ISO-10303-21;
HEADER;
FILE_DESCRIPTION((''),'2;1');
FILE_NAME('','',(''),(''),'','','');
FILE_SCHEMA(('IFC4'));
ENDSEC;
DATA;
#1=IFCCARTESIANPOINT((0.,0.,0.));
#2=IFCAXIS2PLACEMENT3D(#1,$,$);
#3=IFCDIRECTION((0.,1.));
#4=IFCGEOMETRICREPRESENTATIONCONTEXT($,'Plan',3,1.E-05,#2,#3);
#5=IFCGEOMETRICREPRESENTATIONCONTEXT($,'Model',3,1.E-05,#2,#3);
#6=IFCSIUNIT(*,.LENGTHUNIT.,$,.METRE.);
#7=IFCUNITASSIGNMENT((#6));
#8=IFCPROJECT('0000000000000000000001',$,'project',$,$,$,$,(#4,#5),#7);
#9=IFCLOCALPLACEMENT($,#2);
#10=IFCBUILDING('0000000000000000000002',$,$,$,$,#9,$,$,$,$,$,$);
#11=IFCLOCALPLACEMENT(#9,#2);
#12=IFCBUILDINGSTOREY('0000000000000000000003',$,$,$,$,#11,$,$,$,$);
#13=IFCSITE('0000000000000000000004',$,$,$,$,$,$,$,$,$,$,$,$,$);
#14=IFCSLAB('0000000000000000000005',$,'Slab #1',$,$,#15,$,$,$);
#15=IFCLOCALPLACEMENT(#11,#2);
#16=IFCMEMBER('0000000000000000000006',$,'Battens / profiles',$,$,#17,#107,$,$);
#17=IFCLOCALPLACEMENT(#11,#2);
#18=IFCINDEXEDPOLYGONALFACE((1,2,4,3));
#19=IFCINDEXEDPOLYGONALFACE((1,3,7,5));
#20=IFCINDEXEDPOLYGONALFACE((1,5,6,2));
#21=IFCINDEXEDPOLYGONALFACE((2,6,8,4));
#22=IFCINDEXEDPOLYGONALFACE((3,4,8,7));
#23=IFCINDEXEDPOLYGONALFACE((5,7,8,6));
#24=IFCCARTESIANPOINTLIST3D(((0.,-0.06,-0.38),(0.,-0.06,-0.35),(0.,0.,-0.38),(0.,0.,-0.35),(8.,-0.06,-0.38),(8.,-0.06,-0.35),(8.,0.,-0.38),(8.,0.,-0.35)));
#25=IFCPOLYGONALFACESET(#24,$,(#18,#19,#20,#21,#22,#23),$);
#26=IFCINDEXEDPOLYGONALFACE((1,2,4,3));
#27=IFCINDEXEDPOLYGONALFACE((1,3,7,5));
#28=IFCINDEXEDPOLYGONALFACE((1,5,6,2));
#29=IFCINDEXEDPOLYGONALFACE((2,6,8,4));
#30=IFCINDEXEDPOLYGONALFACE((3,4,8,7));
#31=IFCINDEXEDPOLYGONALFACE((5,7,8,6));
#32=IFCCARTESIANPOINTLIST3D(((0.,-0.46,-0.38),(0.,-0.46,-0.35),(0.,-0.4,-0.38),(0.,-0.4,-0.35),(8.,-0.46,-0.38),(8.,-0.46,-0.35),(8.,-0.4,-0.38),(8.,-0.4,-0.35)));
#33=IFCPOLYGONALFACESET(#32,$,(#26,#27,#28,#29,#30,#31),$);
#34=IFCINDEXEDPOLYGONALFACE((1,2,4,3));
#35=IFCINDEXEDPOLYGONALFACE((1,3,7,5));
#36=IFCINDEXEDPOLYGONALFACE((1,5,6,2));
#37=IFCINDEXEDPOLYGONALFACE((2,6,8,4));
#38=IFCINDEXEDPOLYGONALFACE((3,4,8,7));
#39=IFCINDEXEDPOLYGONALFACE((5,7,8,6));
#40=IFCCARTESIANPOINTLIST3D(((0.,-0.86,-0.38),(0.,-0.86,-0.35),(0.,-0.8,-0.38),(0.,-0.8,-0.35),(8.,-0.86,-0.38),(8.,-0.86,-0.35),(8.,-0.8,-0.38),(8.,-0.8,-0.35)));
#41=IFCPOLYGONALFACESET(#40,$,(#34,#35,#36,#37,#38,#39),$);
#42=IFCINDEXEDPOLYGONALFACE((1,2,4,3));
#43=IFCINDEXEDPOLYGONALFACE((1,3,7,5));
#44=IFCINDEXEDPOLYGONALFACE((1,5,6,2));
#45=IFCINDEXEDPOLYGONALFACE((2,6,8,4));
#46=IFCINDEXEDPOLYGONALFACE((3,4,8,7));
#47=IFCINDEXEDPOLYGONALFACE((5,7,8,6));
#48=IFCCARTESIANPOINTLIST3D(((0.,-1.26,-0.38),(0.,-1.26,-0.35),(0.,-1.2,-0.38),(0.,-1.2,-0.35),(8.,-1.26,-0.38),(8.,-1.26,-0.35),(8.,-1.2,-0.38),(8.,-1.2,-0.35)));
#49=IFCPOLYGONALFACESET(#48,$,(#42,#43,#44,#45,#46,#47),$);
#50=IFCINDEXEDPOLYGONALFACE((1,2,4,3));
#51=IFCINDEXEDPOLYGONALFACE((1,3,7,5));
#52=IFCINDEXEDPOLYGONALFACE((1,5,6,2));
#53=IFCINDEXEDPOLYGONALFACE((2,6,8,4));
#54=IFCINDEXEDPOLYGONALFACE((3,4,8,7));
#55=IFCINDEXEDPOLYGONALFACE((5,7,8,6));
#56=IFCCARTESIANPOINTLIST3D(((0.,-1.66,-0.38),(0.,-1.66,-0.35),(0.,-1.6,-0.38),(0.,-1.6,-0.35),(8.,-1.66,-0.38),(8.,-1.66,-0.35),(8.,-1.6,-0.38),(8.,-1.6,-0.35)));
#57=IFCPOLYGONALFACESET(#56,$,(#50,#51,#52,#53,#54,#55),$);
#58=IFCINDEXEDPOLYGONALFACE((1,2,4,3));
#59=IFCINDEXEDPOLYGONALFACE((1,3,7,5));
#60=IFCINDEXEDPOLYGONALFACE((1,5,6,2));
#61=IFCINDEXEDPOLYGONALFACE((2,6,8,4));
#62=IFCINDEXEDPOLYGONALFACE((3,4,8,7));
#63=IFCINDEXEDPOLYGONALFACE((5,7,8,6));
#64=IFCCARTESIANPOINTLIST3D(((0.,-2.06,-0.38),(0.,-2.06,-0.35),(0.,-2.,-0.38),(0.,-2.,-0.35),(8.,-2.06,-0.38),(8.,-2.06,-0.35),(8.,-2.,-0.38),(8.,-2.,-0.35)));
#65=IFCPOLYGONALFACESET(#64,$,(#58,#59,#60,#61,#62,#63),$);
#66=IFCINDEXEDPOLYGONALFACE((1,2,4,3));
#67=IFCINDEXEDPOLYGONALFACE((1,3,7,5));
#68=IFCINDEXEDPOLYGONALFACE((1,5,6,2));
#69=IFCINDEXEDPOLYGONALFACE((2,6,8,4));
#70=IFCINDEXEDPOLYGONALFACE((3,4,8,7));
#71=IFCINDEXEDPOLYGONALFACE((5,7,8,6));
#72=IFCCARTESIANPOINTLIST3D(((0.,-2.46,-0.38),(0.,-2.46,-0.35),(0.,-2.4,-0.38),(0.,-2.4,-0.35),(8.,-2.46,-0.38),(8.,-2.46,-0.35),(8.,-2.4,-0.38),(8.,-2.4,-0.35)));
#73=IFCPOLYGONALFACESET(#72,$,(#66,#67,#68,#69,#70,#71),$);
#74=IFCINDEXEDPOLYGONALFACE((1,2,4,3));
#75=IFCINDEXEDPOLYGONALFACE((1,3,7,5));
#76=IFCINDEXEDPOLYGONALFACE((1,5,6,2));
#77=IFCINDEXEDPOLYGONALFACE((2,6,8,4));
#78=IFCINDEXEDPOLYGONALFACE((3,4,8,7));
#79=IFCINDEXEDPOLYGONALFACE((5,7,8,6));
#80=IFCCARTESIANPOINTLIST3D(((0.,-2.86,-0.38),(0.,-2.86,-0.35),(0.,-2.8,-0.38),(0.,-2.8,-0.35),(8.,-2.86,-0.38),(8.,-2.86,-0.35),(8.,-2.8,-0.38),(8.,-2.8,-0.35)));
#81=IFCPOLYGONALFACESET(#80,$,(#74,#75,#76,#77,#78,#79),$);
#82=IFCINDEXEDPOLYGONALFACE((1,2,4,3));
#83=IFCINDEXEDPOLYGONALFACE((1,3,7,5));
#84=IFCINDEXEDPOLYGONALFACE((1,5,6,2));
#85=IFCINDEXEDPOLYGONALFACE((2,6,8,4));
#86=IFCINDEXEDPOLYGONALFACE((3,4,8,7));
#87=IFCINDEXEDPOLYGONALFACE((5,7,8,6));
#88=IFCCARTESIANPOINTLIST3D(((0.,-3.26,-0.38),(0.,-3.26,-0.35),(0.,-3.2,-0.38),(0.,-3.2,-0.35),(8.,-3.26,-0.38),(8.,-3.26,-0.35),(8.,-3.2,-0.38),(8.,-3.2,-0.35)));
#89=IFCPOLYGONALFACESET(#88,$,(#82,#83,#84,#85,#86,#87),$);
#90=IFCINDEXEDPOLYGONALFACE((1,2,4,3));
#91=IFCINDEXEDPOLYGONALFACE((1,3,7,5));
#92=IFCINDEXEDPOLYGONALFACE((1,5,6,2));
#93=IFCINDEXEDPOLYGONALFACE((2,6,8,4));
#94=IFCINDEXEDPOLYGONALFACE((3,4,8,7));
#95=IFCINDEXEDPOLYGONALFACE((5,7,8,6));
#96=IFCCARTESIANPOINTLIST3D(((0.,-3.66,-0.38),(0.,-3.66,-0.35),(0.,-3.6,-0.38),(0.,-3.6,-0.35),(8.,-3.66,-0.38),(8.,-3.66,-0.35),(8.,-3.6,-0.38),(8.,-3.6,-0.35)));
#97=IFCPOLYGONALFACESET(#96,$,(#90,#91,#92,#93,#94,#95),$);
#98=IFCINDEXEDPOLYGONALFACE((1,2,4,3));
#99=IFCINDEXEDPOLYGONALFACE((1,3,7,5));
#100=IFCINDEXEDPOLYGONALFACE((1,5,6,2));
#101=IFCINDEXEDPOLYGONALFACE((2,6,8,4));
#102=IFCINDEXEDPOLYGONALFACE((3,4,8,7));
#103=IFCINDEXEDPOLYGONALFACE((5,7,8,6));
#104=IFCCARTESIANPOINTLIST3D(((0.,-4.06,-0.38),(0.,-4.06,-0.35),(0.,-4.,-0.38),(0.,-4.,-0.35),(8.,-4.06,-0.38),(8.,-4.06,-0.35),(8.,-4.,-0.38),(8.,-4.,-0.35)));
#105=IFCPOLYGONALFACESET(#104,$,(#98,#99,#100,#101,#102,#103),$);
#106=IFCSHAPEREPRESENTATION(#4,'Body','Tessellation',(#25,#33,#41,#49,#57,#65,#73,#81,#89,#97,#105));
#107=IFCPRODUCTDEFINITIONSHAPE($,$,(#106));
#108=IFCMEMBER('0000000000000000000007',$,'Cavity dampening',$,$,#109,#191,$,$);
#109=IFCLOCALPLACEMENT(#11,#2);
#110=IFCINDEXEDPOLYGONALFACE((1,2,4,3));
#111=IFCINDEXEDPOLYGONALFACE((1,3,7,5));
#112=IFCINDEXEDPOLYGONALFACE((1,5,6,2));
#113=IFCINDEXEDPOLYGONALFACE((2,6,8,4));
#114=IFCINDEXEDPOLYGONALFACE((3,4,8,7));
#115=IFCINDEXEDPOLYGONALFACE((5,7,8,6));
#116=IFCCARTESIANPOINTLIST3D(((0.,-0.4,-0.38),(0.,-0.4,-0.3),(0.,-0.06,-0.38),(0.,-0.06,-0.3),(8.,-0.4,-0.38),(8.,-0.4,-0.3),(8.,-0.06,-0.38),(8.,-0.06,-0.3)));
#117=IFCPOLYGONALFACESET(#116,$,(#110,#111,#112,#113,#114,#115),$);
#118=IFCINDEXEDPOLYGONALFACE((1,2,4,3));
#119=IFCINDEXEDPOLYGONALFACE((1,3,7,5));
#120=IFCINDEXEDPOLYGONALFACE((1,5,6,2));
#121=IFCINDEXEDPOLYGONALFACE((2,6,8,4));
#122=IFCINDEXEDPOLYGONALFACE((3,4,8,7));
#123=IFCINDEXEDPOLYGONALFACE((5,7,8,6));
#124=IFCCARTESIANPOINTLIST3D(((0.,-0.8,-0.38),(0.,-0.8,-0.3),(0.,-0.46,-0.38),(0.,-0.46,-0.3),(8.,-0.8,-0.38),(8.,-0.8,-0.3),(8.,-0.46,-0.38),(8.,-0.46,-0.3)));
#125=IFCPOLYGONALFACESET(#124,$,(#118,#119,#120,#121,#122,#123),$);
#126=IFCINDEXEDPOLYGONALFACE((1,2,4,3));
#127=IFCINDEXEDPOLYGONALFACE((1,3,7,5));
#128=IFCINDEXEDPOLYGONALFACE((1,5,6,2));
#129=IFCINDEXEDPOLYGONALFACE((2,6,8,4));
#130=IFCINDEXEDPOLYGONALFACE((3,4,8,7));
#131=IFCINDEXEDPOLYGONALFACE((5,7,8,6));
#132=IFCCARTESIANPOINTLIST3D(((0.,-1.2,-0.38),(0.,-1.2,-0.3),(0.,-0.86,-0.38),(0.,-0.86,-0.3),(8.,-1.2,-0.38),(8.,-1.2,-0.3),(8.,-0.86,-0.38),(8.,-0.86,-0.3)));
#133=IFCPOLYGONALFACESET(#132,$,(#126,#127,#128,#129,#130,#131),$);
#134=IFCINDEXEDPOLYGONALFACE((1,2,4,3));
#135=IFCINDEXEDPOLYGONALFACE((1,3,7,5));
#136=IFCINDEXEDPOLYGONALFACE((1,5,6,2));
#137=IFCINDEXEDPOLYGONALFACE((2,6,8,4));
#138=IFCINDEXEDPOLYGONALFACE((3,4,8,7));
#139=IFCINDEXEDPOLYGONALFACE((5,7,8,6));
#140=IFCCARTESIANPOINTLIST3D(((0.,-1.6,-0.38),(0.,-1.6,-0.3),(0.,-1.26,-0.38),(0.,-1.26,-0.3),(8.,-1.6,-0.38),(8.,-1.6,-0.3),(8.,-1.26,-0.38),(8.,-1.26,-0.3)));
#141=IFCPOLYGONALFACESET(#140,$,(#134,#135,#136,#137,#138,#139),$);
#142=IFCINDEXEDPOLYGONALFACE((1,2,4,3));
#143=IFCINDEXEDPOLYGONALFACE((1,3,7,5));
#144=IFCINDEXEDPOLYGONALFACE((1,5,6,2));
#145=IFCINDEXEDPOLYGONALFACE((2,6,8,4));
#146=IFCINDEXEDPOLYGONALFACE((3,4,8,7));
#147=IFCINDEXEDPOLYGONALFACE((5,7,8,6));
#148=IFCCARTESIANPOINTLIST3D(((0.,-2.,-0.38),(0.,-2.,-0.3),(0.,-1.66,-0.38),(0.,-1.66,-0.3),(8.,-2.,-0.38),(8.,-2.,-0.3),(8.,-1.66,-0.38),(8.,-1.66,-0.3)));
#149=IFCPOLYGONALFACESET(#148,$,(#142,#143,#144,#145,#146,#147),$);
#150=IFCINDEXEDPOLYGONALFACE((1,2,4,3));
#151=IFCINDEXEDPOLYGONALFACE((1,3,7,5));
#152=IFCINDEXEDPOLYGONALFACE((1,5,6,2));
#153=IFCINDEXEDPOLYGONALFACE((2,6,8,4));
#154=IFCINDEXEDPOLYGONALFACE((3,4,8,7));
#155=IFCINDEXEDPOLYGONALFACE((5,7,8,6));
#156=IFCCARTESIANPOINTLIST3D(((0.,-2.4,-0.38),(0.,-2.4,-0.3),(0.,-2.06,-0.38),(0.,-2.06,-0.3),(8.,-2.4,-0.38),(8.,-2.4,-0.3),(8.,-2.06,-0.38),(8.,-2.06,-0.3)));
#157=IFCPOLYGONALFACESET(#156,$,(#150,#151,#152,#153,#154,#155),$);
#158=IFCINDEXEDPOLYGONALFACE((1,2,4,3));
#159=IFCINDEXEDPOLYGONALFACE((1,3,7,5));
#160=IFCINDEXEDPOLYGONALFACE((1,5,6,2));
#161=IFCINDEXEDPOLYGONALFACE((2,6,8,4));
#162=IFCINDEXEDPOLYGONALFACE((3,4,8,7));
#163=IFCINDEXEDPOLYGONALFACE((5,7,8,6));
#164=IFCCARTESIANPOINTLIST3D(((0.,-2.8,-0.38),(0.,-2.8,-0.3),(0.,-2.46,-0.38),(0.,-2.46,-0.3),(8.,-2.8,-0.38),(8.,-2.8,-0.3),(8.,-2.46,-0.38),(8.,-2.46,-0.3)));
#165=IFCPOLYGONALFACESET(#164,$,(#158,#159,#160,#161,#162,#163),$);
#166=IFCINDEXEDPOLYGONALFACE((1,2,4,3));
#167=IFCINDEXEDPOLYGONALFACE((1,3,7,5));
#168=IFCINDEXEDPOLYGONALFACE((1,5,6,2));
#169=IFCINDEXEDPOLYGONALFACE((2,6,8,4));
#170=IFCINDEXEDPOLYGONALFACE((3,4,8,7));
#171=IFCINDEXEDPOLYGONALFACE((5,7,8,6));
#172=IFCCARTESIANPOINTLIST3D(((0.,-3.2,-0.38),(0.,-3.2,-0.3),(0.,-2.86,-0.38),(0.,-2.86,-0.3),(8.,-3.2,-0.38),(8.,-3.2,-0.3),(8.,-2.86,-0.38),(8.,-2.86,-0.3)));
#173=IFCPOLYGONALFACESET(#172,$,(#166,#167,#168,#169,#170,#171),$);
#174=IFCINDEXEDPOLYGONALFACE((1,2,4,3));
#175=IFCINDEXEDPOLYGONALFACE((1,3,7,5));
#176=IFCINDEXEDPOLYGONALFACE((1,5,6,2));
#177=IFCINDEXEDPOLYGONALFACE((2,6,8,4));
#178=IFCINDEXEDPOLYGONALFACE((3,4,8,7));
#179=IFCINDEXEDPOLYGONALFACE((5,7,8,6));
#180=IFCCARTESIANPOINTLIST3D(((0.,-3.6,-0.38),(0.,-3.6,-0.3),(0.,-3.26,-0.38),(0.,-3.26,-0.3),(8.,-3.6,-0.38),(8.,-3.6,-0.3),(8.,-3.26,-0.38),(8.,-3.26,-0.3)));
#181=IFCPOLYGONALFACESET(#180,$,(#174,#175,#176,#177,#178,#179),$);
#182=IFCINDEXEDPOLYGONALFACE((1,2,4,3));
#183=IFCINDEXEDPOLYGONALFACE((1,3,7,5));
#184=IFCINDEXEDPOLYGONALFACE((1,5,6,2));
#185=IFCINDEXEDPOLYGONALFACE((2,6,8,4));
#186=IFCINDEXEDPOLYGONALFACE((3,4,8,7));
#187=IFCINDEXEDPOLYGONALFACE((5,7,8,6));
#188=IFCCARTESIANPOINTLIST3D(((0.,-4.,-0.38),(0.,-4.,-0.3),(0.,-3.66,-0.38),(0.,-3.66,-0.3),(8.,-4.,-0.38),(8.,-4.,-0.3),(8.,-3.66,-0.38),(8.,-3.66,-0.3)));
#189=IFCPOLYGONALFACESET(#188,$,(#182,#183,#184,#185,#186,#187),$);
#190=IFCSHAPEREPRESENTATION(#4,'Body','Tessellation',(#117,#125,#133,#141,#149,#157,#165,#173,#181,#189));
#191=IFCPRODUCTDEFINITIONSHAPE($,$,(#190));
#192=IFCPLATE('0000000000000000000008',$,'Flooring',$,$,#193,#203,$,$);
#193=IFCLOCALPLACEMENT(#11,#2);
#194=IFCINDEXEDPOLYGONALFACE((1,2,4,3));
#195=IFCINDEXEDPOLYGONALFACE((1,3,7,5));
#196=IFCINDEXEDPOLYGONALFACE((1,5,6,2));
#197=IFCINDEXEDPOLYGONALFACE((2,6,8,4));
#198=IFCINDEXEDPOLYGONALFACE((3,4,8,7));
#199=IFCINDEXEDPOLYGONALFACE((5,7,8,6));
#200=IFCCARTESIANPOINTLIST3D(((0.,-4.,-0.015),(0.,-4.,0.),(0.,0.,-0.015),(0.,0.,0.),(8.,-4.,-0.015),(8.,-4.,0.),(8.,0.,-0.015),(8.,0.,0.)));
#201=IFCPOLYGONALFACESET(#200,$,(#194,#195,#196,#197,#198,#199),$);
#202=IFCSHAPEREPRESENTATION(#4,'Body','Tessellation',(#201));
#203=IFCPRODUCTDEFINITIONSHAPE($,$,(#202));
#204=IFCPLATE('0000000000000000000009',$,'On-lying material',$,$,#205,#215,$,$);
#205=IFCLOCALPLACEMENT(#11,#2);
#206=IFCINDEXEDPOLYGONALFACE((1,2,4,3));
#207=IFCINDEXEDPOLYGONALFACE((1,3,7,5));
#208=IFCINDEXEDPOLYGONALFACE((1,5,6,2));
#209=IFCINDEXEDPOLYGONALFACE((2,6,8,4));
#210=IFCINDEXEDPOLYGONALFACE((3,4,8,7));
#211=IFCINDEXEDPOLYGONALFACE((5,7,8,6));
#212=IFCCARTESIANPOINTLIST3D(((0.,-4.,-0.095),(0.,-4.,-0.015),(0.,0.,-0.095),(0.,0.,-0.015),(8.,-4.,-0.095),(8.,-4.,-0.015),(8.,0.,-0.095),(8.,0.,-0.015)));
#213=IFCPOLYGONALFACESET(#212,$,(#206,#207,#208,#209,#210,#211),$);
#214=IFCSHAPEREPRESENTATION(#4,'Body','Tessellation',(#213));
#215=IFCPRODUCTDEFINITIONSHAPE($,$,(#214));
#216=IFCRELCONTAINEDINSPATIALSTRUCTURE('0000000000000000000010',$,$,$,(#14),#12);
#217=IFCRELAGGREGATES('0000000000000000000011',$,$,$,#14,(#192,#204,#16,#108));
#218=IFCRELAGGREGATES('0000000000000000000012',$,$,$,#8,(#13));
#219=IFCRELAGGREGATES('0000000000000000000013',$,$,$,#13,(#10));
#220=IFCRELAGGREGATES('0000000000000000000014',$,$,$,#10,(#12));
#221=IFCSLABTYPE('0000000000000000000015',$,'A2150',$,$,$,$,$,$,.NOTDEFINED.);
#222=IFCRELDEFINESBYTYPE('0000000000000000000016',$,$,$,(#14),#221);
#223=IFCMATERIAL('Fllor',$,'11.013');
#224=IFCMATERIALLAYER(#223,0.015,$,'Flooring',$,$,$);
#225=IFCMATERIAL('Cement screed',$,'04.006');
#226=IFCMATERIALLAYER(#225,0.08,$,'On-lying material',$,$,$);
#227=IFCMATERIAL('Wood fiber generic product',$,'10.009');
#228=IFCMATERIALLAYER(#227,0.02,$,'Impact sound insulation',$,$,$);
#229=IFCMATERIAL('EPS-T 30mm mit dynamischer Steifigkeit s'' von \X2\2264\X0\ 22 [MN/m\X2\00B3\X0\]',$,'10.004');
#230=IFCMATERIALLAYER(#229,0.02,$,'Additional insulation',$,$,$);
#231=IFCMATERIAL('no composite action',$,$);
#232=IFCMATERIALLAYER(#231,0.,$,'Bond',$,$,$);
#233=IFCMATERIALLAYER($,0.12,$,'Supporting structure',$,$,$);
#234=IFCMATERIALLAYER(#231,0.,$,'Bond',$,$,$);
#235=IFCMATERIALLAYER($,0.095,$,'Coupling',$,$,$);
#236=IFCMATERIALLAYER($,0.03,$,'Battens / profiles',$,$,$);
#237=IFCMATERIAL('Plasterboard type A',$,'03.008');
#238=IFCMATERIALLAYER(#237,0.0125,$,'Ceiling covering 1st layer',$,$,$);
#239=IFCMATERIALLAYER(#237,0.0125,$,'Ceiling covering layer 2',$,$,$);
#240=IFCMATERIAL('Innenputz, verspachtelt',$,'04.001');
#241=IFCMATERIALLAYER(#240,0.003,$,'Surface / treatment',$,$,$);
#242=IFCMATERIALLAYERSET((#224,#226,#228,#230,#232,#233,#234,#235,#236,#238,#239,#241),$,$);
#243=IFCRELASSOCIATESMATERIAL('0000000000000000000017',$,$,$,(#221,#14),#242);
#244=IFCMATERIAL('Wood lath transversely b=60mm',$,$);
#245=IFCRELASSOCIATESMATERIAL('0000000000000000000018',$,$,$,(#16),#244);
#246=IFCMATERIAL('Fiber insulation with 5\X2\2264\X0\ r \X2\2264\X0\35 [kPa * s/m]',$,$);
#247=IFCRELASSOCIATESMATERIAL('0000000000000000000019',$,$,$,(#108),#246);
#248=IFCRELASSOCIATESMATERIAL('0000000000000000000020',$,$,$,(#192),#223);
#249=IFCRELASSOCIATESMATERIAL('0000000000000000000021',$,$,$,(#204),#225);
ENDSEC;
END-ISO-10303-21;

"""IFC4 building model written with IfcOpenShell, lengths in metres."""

from ifc_helpers import new_model, si_unit, direction, frame, frame_2d, origin, origin_with_axes, place, context, project, spatial, rectangle, extrude, material, layer, layer_set, type_object, element, aggregate, save


model = new_model("IFC4")

# Units and contexts
plan_context = context("Plan", 3, precision=1e-05, world=origin(), true_north=direction((0.0, 1.0)))
model_context = context("Model", 3, precision=1e-05, world=origin(), true_north=direction((0.0, 1.0)))
ifc_project = project(units=[si_unit("LENGTHUNIT", "METRE")], contexts=[plan_context, model_context])

# Site, building, storey
site = spatial("IfcSite", under=ifc_project)
building_placement = place(None, origin())
building = spatial("IfcBuilding", under=site, at=building_placement)
storey_placement = place(building_placement, origin())
storey = spatial("IfcBuildingStorey", under=building, at=storey_placement)

# Slab, members, plates
ifc_material_1 = material(Name="Fllor", Category="11.013")
ifc_layer_1 = layer(ifc_material_1, 0.015, Name="Flooring")
ifc_material_2 = material(Name="Cement screed", Category="04.006")
ifc_layer_2 = layer(ifc_material_2, 0.08, Name="On-lying material")
ifc_material_3 = material(Name="Wood fiber generic product", Category="10.009")
ifc_layer_3 = layer(ifc_material_3, 0.02, Name="Impact sound insulation")
ifc_material_4 = material(Name="EPS-T 30mm mit dynamischer Steifigkeit s' von ≤ 22 [MN/m³]", Category="10.004")
ifc_layer_4 = layer(ifc_material_4, 0.02, Name="Additional insulation")
ifc_material_5 = material(Name="no composite action")
ifc_layer_5 = layer(ifc_material_5, 0.0, Name="Bond")
ifc_layer_6 = layer(None, 0.12, Name="Supporting structure")
ifc_layer_7 = layer(ifc_material_5, 0.0, Name="Bond")
ifc_layer_8 = layer(None, 0.095, Name="Coupling")
ifc_layer_9 = layer(None, 0.03, Name="Battens / profiles")
ifc_material_6 = material(Name="Plasterboard type A", Category="03.008")
ifc_layer_10 = layer(ifc_material_6, 0.0125, Name="Ceiling covering 1st layer")
ifc_layer_11 = layer(ifc_material_6, 0.0125, Name="Ceiling covering layer 2")
ifc_material_7 = material(Name="Innenputz, verspachtelt", Category="04.001")
ifc_layer_12 = layer(ifc_material_7, 0.003, Name="Surface / treatment")
ifc_layer_set = layer_set([ifc_layer_1, ifc_layer_2, ifc_layer_3, ifc_layer_4, ifc_layer_5, ifc_layer_6, ifc_layer_7, ifc_layer_8, ifc_layer_9, ifc_layer_10, ifc_layer_11, ifc_layer_12])
slab_type = type_object("IfcSlabType", Name="A2150", PredefinedType="NOTDEFINED", material=ifc_layer_set)
slab_placement = place(None, frame((0.0, 0.0, 0.0), z_axis=(0.0, 0.0, -1.0), x_axis=(1.0, 0.0, 0.0)))
slab = element("IfcSlab", 1, at=slab_placement, inside=storey, type_object=slab_type, material=ifc_layer_set, Name="Slab #1")
ifc_material_8 = material(Name="Wood lath transversely b=60mm")
member_1_placement = place(slab_placement, origin())
member_1 = element("IfcMember", 2, at=member_1_placement, material=ifc_material_8, Name="Battens / profiles", context=plan_context, shape_type="SweptSolid", body=[
    extrude(rectangle(XDim=0.06, YDim=0.03, at=frame_2d((0.03, 0.015), x_axis=(1.0, 0.0))), frame((0.0, 0.0, 0.35), z_axis=(1.0, 0.0, 0.0), x_axis=(0.0, 1.0, 0.0)), (0.0, 0.0, 1.0), 8.0),
    extrude(rectangle(XDim=0.06, YDim=0.03, at=frame_2d((0.03, 0.015), x_axis=(1.0, 0.0))), frame((0.0, 0.4, 0.35), z_axis=(1.0, 0.0, 0.0), x_axis=(0.0, 1.0, 0.0)), (0.0, 0.0, 1.0), 8.0),
    extrude(rectangle(XDim=0.06, YDim=0.03, at=frame_2d((0.03, 0.015), x_axis=(1.0, 0.0))), frame((0.0, 0.8, 0.35), z_axis=(1.0, 0.0, 0.0), x_axis=(0.0, 1.0, 0.0)), (0.0, 0.0, 1.0), 8.0),
    extrude(rectangle(XDim=0.06, YDim=0.03, at=frame_2d((0.03, 0.015), x_axis=(1.0, 0.0))), frame((0.0, 1.2, 0.35), z_axis=(1.0, 0.0, 0.0), x_axis=(0.0, 1.0, 0.0)), (0.0, 0.0, 1.0), 8.0),
    extrude(rectangle(XDim=0.06, YDim=0.03, at=frame_2d((0.03, 0.015), x_axis=(1.0, 0.0))), frame((0.0, 1.6, 0.35), z_axis=(1.0, 0.0, 0.0), x_axis=(0.0, 1.0, 0.0)), (0.0, 0.0, 1.0), 8.0),
    extrude(rectangle(XDim=0.06, YDim=0.03, at=frame_2d((0.03, 0.015), x_axis=(1.0, 0.0))), frame((0.0, 2.0, 0.35), z_axis=(1.0, 0.0, 0.0), x_axis=(0.0, 1.0, 0.0)), (0.0, 0.0, 1.0), 8.0),
    extrude(rectangle(XDim=0.06, YDim=0.03, at=frame_2d((0.03, 0.015), x_axis=(1.0, 0.0))), frame((0.0, 2.4, 0.35), z_axis=(1.0, 0.0, 0.0), x_axis=(0.0, 1.0, 0.0)), (0.0, 0.0, 1.0), 8.0),
    extrude(rectangle(XDim=0.06, YDim=0.03, at=frame_2d((0.03, 0.015), x_axis=(1.0, 0.0))), frame((0.0, 2.8, 0.35), z_axis=(1.0, 0.0, 0.0), x_axis=(0.0, 1.0, 0.0)), (0.0, 0.0, 1.0), 8.0),
    extrude(rectangle(XDim=0.06, YDim=0.03, at=frame_2d((0.03, 0.015), x_axis=(1.0, 0.0))), frame((0.0, 3.2, 0.35), z_axis=(1.0, 0.0, 0.0), x_axis=(0.0, 1.0, 0.0)), (0.0, 0.0, 1.0), 8.0),
    extrude(rectangle(XDim=0.06, YDim=0.03, at=frame_2d((0.03, 0.015), x_axis=(1.0, 0.0))), frame((0.0, 3.6, 0.35), z_axis=(1.0, 0.0, 0.0), x_axis=(0.0, 1.0, 0.0)), (0.0, 0.0, 1.0), 8.0),
    extrude(rectangle(XDim=0.06, YDim=0.03, at=frame_2d((0.03, 0.015), x_axis=(1.0, 0.0))), frame((0.0, 4.0, 0.35), z_axis=(1.0, 0.0, 0.0), x_axis=(0.0, 1.0, 0.0)), (0.0, 0.0, 1.0), 8.0),
])
ifc_material_9 = material(Name="Fiber insulation with 5≤ r ≤35 [kPa * s/m]")
member_2_placement = place(slab_placement, origin())
member_2 = element("IfcMember", 3, at=member_2_placement, material=ifc_material_9, Name="Cavity dampening", context=plan_context, shape_type="SweptSolid", body=[
    extrude(rectangle(XDim=0.34, YDim=0.08, at=frame_2d((0.17, 0.04), x_axis=(1.0, 0.0))), frame((0.0, 0.06, 0.3), z_axis=(1.0, 0.0, 0.0), x_axis=(0.0, 1.0, 0.0)), (0.0, 0.0, 1.0), 8.0),
    extrude(rectangle(XDim=0.34, YDim=0.08, at=frame_2d((0.17, 0.04), x_axis=(1.0, 0.0))), frame((0.0, 0.46, 0.3), z_axis=(1.0, 0.0, 0.0), x_axis=(0.0, 1.0, 0.0)), (0.0, 0.0, 1.0), 8.0),
    extrude(rectangle(XDim=0.34, YDim=0.08, at=frame_2d((0.17, 0.04), x_axis=(1.0, 0.0))), frame((0.0, 0.86, 0.3), z_axis=(1.0, 0.0, 0.0), x_axis=(0.0, 1.0, 0.0)), (0.0, 0.0, 1.0), 8.0),
    extrude(rectangle(XDim=0.34, YDim=0.08, at=frame_2d((0.17, 0.04), x_axis=(1.0, 0.0))), frame((0.0, 1.26, 0.3), z_axis=(1.0, 0.0, 0.0), x_axis=(0.0, 1.0, 0.0)), (0.0, 0.0, 1.0), 8.0),
    extrude(rectangle(XDim=0.34, YDim=0.08, at=frame_2d((0.17, 0.04), x_axis=(1.0, 0.0))), frame((0.0, 1.66, 0.3), z_axis=(1.0, 0.0, 0.0), x_axis=(0.0, 1.0, 0.0)), (0.0, 0.0, 1.0), 8.0),
    extrude(rectangle(XDim=0.34, YDim=0.08, at=frame_2d((0.17, 0.04), x_axis=(1.0, 0.0))), frame((0.0, 2.06, 0.3), z_axis=(1.0, 0.0, 0.0), x_axis=(0.0, 1.0, 0.0)), (0.0, 0.0, 1.0), 8.0),
    extrude(rectangle(XDim=0.34, YDim=0.08, at=frame_2d((0.17, 0.04), x_axis=(1.0, 0.0))), frame((0.0, 2.46, 0.3), z_axis=(1.0, 0.0, 0.0), x_axis=(0.0, 1.0, 0.0)), (0.0, 0.0, 1.0), 8.0),
    extrude(rectangle(XDim=0.34, YDim=0.08, at=frame_2d((0.17, 0.04), x_axis=(1.0, 0.0))), frame((0.0, 2.86, 0.3), z_axis=(1.0, 0.0, 0.0), x_axis=(0.0, 1.0, 0.0)), (0.0, 0.0, 1.0), 8.0),
    extrude(rectangle(XDim=0.34, YDim=0.08, at=frame_2d((0.17, 0.04), x_axis=(1.0, 0.0))), frame((0.0, 3.26, 0.3), z_axis=(1.0, 0.0, 0.0), x_axis=(0.0, 1.0, 0.0)), (0.0, 0.0, 1.0), 8.0),
    extrude(rectangle(XDim=0.34, YDim=0.08, at=frame_2d((0.17, 0.04), x_axis=(1.0, 0.0))), frame((0.0, 3.66, 0.3), z_axis=(1.0, 0.0, 0.0), x_axis=(0.0, 1.0, 0.0)), (0.0, 0.0, 1.0), 8.0),
])
plate_1_placement = place(slab_placement, origin())
plate_1 = element("IfcPlate", 4, at=plate_1_placement, material=ifc_material_1, Name="Flooring", context=plan_context, shape_type="SweptSolid", body=[
    extrude(rectangle(XDim=8.0, YDim=4.0, at=frame_2d((4.0, 2.0), x_axis=(1.0, 0.0))), origin_with_axes(), (0.0, 0.0, 1.0), 0.015),
])
plate_2_placement = place(slab_placement, origin())
plate_2 = element("IfcPlate", 5, at=plate_2_placement, material=ifc_material_2, Name="On-lying material", context=plan_context, shape_type="SweptSolid", body=[
    extrude(rectangle(XDim=8.0, YDim=4.0, at=frame_2d((4.0, 2.0), x_axis=(1.0, 0.0))), frame((0.0, 0.0, 0.015), z_axis=(0.0, 0.0, 1.0), x_axis=(1.0, 0.0, 0.0)), (0.0, 0.0, 1.0), 0.08),
])
aggregate(slab, [plate_1, plate_2, member_1, member_2])

save(model, "model.ifc")
